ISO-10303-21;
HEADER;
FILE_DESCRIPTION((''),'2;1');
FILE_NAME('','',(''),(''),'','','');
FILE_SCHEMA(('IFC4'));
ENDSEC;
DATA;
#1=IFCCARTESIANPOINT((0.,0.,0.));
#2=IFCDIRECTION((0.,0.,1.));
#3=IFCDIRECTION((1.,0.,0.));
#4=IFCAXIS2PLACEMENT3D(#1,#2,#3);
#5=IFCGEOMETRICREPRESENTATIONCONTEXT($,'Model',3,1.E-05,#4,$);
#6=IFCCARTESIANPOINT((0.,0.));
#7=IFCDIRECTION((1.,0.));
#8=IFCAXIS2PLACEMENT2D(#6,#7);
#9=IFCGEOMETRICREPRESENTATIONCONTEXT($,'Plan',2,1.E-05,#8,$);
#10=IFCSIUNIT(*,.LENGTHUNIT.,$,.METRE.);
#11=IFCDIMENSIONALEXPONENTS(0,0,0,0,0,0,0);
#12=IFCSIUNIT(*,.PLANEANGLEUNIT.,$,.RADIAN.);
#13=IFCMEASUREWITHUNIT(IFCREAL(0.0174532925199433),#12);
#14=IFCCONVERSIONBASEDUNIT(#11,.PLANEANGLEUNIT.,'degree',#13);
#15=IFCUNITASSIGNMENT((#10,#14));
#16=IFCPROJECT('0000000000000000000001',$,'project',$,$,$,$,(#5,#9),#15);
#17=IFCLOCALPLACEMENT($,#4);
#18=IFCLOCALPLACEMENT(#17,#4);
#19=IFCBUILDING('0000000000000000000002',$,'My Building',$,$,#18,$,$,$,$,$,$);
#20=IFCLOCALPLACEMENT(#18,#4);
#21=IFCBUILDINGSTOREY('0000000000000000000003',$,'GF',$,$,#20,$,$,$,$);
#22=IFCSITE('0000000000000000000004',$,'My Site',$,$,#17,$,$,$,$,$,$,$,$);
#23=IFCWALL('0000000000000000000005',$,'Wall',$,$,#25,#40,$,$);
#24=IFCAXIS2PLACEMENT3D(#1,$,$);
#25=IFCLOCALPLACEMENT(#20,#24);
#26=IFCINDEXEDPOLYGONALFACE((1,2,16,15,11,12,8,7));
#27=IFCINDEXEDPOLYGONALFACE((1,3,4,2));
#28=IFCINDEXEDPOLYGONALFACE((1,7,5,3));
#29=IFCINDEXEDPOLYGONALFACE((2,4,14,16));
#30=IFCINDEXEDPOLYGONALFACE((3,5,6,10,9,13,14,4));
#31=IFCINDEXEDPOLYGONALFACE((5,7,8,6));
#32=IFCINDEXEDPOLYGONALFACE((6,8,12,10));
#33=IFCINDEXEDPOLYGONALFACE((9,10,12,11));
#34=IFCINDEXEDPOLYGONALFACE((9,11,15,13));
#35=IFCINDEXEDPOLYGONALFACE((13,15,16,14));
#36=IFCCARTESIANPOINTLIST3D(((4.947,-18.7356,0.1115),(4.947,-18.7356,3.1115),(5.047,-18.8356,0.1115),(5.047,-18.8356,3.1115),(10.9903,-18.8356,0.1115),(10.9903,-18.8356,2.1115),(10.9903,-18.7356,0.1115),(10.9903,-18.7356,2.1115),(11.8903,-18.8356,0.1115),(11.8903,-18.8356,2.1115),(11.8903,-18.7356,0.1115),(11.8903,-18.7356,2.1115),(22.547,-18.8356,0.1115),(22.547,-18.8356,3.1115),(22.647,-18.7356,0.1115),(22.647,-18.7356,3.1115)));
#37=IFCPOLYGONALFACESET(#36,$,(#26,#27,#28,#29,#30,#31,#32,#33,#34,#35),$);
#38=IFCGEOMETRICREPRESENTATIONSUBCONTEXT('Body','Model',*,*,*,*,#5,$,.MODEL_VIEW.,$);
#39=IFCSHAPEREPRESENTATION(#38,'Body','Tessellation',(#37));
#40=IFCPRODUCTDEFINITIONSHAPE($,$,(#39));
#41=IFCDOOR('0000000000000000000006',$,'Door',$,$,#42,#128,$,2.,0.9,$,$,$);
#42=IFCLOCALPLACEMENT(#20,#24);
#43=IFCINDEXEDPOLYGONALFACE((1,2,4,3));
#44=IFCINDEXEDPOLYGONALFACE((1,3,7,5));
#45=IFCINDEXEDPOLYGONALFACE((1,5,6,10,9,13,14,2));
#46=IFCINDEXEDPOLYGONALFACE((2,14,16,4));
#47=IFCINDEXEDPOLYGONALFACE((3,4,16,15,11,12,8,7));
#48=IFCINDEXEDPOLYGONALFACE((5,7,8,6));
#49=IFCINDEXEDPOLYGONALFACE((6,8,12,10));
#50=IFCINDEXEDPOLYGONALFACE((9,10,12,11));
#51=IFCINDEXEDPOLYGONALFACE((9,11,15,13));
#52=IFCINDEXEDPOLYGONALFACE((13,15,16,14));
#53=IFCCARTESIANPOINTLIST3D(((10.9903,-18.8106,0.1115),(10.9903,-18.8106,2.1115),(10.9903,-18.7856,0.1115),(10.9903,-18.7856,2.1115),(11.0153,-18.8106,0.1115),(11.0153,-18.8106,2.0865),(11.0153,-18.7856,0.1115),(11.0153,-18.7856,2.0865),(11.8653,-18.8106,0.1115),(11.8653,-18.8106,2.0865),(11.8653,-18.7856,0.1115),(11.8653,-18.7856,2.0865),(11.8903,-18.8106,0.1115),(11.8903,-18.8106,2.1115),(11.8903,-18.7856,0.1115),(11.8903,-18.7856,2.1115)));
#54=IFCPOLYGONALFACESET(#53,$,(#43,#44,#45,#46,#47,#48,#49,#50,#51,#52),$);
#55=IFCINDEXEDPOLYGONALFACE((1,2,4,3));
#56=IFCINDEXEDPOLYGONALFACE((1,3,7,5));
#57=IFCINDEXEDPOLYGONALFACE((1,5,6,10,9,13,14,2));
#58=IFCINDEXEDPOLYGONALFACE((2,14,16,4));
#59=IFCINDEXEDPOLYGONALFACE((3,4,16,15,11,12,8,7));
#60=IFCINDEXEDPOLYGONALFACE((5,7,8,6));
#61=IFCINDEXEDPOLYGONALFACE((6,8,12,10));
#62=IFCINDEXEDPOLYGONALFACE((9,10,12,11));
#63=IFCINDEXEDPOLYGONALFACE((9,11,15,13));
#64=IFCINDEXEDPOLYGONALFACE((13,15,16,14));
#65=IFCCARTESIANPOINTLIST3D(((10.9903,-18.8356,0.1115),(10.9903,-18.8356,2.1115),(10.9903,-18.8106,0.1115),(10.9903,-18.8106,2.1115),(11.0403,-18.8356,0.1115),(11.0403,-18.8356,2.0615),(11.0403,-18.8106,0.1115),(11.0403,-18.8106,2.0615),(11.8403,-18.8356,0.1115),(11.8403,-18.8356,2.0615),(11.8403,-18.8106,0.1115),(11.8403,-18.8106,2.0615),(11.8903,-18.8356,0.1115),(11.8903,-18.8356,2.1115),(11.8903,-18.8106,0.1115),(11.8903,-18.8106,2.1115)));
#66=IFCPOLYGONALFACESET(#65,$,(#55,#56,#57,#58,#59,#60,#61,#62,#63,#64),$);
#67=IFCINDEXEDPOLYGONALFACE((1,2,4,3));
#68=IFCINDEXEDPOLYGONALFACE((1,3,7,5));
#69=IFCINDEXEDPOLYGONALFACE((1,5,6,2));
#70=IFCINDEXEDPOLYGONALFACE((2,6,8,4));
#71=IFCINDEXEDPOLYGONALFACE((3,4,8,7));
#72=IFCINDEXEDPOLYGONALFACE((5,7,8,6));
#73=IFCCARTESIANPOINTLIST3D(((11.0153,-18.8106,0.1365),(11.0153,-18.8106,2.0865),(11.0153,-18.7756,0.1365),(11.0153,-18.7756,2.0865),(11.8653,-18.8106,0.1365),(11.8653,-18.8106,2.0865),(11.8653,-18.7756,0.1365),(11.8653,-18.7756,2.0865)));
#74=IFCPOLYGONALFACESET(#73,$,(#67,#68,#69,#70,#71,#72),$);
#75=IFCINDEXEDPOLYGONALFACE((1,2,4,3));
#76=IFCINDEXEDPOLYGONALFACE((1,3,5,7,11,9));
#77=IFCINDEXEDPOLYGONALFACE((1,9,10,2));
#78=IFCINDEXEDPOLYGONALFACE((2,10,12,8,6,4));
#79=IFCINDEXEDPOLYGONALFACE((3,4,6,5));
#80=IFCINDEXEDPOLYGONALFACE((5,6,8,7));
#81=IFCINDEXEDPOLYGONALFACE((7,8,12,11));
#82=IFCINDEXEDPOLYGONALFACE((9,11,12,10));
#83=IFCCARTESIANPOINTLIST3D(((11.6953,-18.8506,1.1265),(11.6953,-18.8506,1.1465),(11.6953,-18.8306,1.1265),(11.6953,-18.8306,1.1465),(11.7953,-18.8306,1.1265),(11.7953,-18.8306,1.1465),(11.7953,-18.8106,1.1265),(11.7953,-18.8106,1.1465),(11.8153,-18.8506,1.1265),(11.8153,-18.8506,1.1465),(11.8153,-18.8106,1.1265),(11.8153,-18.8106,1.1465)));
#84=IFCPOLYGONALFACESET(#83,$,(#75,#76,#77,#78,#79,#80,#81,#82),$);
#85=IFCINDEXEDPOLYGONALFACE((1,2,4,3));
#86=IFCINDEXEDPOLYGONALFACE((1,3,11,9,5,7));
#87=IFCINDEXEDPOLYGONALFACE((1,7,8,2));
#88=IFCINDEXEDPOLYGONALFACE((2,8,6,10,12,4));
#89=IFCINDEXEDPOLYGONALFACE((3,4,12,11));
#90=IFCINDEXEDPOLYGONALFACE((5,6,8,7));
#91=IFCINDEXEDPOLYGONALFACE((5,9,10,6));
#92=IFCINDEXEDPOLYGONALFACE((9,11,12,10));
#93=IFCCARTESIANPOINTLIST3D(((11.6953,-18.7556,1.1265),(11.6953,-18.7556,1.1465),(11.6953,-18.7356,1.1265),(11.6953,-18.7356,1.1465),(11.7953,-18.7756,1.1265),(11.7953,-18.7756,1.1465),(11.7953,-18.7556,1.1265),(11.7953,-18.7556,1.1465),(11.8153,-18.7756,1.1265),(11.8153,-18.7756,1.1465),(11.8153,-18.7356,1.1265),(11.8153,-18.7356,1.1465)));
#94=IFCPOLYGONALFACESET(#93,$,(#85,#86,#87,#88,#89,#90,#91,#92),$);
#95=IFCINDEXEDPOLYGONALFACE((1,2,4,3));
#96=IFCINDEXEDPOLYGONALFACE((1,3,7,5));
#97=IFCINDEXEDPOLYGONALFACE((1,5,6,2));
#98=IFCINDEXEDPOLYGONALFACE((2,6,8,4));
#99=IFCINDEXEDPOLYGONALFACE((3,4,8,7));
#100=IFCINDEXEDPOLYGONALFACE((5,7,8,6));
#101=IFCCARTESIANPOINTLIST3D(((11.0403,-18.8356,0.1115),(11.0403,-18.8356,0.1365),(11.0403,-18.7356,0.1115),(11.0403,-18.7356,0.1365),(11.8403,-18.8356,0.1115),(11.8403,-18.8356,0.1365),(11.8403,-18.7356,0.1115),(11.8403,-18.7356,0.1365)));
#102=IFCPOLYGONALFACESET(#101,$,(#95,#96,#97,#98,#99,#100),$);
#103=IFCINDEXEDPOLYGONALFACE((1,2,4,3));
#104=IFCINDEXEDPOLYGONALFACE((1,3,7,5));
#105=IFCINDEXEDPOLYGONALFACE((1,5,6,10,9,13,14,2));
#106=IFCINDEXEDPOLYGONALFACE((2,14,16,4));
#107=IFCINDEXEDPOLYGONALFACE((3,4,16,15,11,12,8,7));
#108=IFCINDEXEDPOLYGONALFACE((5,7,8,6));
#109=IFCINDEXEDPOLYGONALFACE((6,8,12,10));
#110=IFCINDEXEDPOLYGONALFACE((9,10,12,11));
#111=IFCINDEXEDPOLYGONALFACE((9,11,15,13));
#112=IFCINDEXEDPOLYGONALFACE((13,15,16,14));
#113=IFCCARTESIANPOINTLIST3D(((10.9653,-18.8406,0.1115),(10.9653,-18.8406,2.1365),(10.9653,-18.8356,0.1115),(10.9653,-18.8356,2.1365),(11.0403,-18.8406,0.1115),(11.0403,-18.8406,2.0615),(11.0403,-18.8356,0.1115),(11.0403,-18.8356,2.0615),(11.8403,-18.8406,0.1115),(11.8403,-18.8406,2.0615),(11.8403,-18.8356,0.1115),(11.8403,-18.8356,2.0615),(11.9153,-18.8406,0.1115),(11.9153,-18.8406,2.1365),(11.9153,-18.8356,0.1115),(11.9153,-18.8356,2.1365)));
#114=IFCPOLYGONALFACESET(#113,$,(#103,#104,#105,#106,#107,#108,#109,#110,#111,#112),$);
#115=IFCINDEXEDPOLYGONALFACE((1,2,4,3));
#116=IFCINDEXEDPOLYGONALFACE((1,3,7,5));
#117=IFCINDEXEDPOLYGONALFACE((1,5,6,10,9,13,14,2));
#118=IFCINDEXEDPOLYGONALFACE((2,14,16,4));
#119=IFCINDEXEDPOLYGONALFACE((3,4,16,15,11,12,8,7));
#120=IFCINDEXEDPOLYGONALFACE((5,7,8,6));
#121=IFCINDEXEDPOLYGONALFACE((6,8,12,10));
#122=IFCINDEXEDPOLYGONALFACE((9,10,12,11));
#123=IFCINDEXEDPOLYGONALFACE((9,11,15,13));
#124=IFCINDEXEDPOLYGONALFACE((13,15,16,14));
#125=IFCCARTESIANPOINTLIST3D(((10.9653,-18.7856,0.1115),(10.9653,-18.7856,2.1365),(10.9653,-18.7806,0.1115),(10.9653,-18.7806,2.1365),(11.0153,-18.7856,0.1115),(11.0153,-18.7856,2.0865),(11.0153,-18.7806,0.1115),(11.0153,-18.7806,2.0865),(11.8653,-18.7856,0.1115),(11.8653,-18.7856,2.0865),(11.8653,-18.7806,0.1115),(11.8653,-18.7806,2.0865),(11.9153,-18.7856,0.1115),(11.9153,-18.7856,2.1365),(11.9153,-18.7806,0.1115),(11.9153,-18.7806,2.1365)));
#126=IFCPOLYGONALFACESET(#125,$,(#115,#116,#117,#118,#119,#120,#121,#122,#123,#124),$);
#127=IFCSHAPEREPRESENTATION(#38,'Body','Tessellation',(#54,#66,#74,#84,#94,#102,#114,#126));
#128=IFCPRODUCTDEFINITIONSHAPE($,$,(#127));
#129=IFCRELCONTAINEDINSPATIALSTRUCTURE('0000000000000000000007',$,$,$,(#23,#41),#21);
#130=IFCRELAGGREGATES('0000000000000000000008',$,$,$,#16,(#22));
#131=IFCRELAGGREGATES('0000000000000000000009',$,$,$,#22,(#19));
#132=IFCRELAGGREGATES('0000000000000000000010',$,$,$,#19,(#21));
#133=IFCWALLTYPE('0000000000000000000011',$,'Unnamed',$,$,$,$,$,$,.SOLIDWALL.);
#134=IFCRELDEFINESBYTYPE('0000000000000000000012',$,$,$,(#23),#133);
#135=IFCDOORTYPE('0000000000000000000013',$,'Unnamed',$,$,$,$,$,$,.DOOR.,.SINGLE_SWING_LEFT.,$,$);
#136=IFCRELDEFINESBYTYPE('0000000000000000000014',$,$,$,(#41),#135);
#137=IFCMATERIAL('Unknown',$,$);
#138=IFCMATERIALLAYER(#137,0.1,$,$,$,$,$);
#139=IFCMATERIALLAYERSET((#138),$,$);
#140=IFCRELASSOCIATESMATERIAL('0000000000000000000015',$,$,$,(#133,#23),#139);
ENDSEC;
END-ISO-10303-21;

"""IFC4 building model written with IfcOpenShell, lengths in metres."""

from ifc_helpers import new_model, entity, si_unit, converted_unit, frame, origin_with_axes, origin_2d_with_axis, place, context, subcontext, project, spatial, line, indexed_curve, outline, extrude, shape, source, transform, mapped, material, layer, layer_set, layer_usage, type_object, type_shapes, element, fill, save


model = new_model("IFC4")

# Units and contexts
model_context = context("Model", 3, precision=1e-05, world=origin_with_axes())
plan_context = context("Plan", 2, precision=1e-05, world=origin_2d_with_axis())
body_context_1 = subcontext(model_context, "Body", "Model", "MODEL_VIEW")
body_context_2 = subcontext(plan_context, "Body", "Plan", "PLAN_VIEW")
ifc_project = project(units=[si_unit("LENGTHUNIT", "METRE"), converted_unit("PLANEANGLEUNIT", "degree", entity("IfcReal", 0.0174532925199433), si_unit("PLANEANGLEUNIT", "RADIAN"), dimensions=[0, 0, 0, 0, 0, 0, 0])], contexts=[model_context, plan_context])

# Site, building, storey
site_placement = place(None, origin_with_axes())
site = spatial("IfcSite", under=ifc_project, at=site_placement, Name="My Site")
building_placement = place(site_placement, origin_with_axes())
building = spatial("IfcBuilding", under=site, at=building_placement, Name="My Building")
storey_placement = place(building_placement, origin_with_axes())
storey = spatial("IfcBuildingStorey", under=building, at=storey_placement, Name="GF")

# Shared definitions
ifc_material = material(Name="Unknown")

# Shared definitions
ifc_layer_1 = layer(ifc_material, 0.1)
ifc_layer_set_1 = layer_set([ifc_layer_1])
wall_type = type_object("IfcWallType", Name="Unnamed", PredefinedType="SOLIDWALL", material=ifc_layer_set_1)

# Shared definitions
shared_shape_1 = source(origin_with_axes(), body_context_1, "Body", "SweptSolid", [
    extrude(outline(indexed_curve([(0.0, 0.0), (0.9, 0.0), (0.9, 2.0), (0.0, 2.0)], segments=[line(1, 2, 3, 4, 1)])), frame((0.0, -0.6, 0.0), z_axis=(0.0, -1.0, 0.0), x_axis=(1.0, 0.0, 0.0)), (0.0, 0.0, -1.0), 1.2),
])
door_type = type_object("IfcDoorType", Name="Unnamed", OperationType="SINGLE_SWING_LEFT", PredefinedType="DOOR")
shared_shape_2 = source(origin_with_axes(), body_context_1, "Body", "SweptSolid", [
    extrude(outline(indexed_curve([(0.0, 0.0), (0.0, 2.0), (0.9, 2.0), (0.9, 0.0), (0.875, 0.0), (0.875, 1.975), (0.025, 1.975), (0.025, 0.0)], segments=[line(1, 2, 3, 4, 5, 6, 7, 8, 1)])), frame((0.0, 0.025, 0.0), z_axis=(0.0, -1.0, 0.0), x_axis=(1.0, 0.0, 0.0)), (0.0, 0.0, -1.0), 0.025),
    extrude(outline(indexed_curve([(0.0, 0.0), (0.0, 2.0), (0.9, 2.0), (0.9, 0.0), (0.85, 0.0), (0.85, 1.95), (0.05, 1.95), (0.05, 0.0)], segments=[line(1, 2, 3, 4, 5, 6, 7, 8, 1)])), frame((0.0, 0.0, 0.0), z_axis=(0.0, -1.0, 0.0), x_axis=(1.0, 0.0, 0.0)), (0.0, 0.0, -1.0), 0.025),
    extrude(outline(indexed_curve([(0.0, 0.0), (0.85, 0.0), (0.85, 0.035), (0.0, 0.035)], segments=[line(1, 2, 3, 4, 1)])), frame((0.025, 0.025, 0.025), z_axis=(0.0, 0.0, 1.0), x_axis=(1.0, 0.0, 0.0)), (0.0, 0.0, 1.0), 1.95),
    extrude(outline(indexed_curve([(0.0, 0.0), (0.0, -0.04), (-0.12, -0.04), (-0.12, -0.02), (-0.02, -0.02), (-0.02, 0.0)], segments=[line(1, 2, 3, 4, 5, 6, 1)])), frame((0.825, 0.025, 1.015), z_axis=(0.0, 0.0, 1.0), x_axis=(1.0, 0.0, 0.0)), (0.0, 0.0, 1.0), 0.02),
    extrude(outline(indexed_curve([(0.0, 0.0), (0.0, 0.04), (-0.12, 0.04), (-0.12, 0.02), (-0.02, 0.02), (-0.02, 0.0)], segments=[line(1, 2, 3, 4, 5, 6, 1)])), frame((0.825, 0.06, 1.015), z_axis=(0.0, 0.0, 1.0), x_axis=(1.0, 0.0, 0.0)), (0.0, 0.0, 1.0), 0.02),
    extrude(outline(indexed_curve([(0.0, 0.0), (0.8, 0.0), (0.8, 0.1), (0.0, 0.1)], segments=[line(1, 2, 3, 4, 1)])), frame((0.05, 0.0, 0.0), z_axis=(0.0, 0.0, 1.0), x_axis=(1.0, 0.0, 0.0)), (0.0, 0.0, 1.0), 0.025),
    extrude(outline(indexed_curve([(0.0, 0.0), (0.0, 2.025), (0.95, 2.025), (0.95, 0.0), (0.875, 0.0), (0.875, 1.95), (0.075, 1.95), (0.075, 0.0)], segments=[line(1, 2, 3, 4, 5, 6, 7, 8, 1)])), frame((-0.025, -0.005, 0.0), z_axis=(0.0, -1.0, 0.0), x_axis=(1.0, 0.0, 0.0)), (0.0, 0.0, -1.0), 0.005),
    extrude(outline(indexed_curve([(0.0, 0.0), (0.0, 2.025), (0.95, 2.025), (0.95, 0.0), (0.9, 0.0), (0.9, 1.975), (0.05, 1.975), (0.05, 0.0)], segments=[line(1, 2, 3, 4, 5, 6, 7, 8, 1)])), frame((-0.025, 0.05, 0.0), z_axis=(0.0, -1.0, 0.0), x_axis=(1.0, 0.0, 0.0)), (0.0, 0.0, -1.0), 0.005),
])
shared_shape_3 = source(origin_with_axes(), body_context_2, "Body", "Curve2D", [
    entity("IfcIndexedPolyCurve", entity("IfcCartesianPointList2D", [[0.0, 0.0], [0.0, 0.05], [0.025, 0.05], [0.025, 0.025], [0.05, 0.025], [0.05, 0.0]]), [entity("IfcLineIndex", [1, 2, 3, 4, 5, 6, 1])]),
    entity("IfcIndexedPolyCurve", entity("IfcCartesianPointList2D", [[0.9, 0.0], [0.9, 0.05], [0.875, 0.05], [0.875, 0.025], [0.85, 0.025], [0.85, 0.0]]), [entity("IfcLineIndex", [1, 2, 3, 4, 5, 6, 1])]),
    entity("IfcTrimmedCurve", entity("IfcEllipse", entity("IfcAxis2Placement2D", entity("IfcCartesianPoint", [0.06, 0.05]), entity("IfcDirection", [1.0, 0.0])), 0.815, 0.85), [entity("IfcCartesianPoint", [0.875, 0.05])], [entity("IfcCartesianPoint", [0.06, 0.9])], True, "CARTESIAN"),
    entity("IfcIndexedPolyCurve", entity("IfcCartesianPointList2D", [[0.025, 0.05], [0.06, 0.05], [0.06, 0.9], [0.025, 0.9]]), [entity("IfcLineIndex", [1, 2, 3, 4, 1])]),
])
type_shapes(door_type, [shared_shape_2, shared_shape_3])

# Wall, opening, door
ifc_layer_usage_1 = layer_usage(ifc_layer_set_1, "AXIS2", "POSITIVE", 0.0)
wall_1_placement = place(storey_placement, frame((5.047, -18.8356, 0.1115), z_axis=(0.0, 0.0, 1.0), x_axis=(1.0, 0.0, 0.0)))
wall_1 = element("IfcWall", 1, at=wall_1_placement, inside=storey, type_object=wall_type, material=ifc_layer_usage_1, Name="Wall", context=body_context_1, shape_type="SweptSolid", body=[
    extrude(outline(indexed_curve([(0.0, 0.0), (-0.1, 0.1), (17.6, 0.1), (17.5, 0.0)], segments=[line(1, 2, 3, 4, 1)])), origin_with_axes(), (0.0, 0.0, 1.0), 3.0),
])
opening_1_placement = place(wall_1_placement, frame((5.9433, 0.0, 0.0), z_axis=(0.0, 0.0, 1.0), x_axis=(1.0, 0.0, 0.0)))
opening_1 = element("IfcOpeningElement", 2, at=opening_1_placement, cuts=wall_1, PredefinedType="OPENING", context=body_context_1, shape_type="MappedRepresentation", body=[
    mapped(shared_shape_1, transform((0.0, 0.0, 0.0), x_axis=(1.0, 0.0, 0.0), y_axis=(0.0, 1.0, 0.0), z_axis=(0.0, 0.0, 1.0), scale=1.0)),
])
door_1_placement = place(opening_1_placement, frame((0.0, 0.0, 0.0), z_axis=(0.0, 0.0, 1.0), x_axis=(1.0, 0.0, 0.0)))
door_1 = element("IfcDoor", 3, at=door_1_placement, inside=storey, type_object=door_type, Name="Door", OverallHeight=2.0, OverallWidth=0.9, shapes=[
    shape(body_context_1, "Body", "MappedRepresentation", [mapped(shared_shape_2, transform((0.0, 0.0, 0.0), x_axis=(1.0, 0.0, 0.0), y_axis=(0.0, 1.0, 0.0), z_axis=(0.0, 0.0, 1.0), scale=1.0))]),
    shape(body_context_2, "Body", "MappedRepresentation", [mapped(shared_shape_3, transform((0.0, 0.0, 0.0), x_axis=(1.0, 0.0, 0.0), y_axis=(0.0, 1.0, 0.0), z_axis=(0.0, 0.0, 1.0), scale=1.0))]),
])
fill(opening_1, door_1)

save(model, "model.ifc")
